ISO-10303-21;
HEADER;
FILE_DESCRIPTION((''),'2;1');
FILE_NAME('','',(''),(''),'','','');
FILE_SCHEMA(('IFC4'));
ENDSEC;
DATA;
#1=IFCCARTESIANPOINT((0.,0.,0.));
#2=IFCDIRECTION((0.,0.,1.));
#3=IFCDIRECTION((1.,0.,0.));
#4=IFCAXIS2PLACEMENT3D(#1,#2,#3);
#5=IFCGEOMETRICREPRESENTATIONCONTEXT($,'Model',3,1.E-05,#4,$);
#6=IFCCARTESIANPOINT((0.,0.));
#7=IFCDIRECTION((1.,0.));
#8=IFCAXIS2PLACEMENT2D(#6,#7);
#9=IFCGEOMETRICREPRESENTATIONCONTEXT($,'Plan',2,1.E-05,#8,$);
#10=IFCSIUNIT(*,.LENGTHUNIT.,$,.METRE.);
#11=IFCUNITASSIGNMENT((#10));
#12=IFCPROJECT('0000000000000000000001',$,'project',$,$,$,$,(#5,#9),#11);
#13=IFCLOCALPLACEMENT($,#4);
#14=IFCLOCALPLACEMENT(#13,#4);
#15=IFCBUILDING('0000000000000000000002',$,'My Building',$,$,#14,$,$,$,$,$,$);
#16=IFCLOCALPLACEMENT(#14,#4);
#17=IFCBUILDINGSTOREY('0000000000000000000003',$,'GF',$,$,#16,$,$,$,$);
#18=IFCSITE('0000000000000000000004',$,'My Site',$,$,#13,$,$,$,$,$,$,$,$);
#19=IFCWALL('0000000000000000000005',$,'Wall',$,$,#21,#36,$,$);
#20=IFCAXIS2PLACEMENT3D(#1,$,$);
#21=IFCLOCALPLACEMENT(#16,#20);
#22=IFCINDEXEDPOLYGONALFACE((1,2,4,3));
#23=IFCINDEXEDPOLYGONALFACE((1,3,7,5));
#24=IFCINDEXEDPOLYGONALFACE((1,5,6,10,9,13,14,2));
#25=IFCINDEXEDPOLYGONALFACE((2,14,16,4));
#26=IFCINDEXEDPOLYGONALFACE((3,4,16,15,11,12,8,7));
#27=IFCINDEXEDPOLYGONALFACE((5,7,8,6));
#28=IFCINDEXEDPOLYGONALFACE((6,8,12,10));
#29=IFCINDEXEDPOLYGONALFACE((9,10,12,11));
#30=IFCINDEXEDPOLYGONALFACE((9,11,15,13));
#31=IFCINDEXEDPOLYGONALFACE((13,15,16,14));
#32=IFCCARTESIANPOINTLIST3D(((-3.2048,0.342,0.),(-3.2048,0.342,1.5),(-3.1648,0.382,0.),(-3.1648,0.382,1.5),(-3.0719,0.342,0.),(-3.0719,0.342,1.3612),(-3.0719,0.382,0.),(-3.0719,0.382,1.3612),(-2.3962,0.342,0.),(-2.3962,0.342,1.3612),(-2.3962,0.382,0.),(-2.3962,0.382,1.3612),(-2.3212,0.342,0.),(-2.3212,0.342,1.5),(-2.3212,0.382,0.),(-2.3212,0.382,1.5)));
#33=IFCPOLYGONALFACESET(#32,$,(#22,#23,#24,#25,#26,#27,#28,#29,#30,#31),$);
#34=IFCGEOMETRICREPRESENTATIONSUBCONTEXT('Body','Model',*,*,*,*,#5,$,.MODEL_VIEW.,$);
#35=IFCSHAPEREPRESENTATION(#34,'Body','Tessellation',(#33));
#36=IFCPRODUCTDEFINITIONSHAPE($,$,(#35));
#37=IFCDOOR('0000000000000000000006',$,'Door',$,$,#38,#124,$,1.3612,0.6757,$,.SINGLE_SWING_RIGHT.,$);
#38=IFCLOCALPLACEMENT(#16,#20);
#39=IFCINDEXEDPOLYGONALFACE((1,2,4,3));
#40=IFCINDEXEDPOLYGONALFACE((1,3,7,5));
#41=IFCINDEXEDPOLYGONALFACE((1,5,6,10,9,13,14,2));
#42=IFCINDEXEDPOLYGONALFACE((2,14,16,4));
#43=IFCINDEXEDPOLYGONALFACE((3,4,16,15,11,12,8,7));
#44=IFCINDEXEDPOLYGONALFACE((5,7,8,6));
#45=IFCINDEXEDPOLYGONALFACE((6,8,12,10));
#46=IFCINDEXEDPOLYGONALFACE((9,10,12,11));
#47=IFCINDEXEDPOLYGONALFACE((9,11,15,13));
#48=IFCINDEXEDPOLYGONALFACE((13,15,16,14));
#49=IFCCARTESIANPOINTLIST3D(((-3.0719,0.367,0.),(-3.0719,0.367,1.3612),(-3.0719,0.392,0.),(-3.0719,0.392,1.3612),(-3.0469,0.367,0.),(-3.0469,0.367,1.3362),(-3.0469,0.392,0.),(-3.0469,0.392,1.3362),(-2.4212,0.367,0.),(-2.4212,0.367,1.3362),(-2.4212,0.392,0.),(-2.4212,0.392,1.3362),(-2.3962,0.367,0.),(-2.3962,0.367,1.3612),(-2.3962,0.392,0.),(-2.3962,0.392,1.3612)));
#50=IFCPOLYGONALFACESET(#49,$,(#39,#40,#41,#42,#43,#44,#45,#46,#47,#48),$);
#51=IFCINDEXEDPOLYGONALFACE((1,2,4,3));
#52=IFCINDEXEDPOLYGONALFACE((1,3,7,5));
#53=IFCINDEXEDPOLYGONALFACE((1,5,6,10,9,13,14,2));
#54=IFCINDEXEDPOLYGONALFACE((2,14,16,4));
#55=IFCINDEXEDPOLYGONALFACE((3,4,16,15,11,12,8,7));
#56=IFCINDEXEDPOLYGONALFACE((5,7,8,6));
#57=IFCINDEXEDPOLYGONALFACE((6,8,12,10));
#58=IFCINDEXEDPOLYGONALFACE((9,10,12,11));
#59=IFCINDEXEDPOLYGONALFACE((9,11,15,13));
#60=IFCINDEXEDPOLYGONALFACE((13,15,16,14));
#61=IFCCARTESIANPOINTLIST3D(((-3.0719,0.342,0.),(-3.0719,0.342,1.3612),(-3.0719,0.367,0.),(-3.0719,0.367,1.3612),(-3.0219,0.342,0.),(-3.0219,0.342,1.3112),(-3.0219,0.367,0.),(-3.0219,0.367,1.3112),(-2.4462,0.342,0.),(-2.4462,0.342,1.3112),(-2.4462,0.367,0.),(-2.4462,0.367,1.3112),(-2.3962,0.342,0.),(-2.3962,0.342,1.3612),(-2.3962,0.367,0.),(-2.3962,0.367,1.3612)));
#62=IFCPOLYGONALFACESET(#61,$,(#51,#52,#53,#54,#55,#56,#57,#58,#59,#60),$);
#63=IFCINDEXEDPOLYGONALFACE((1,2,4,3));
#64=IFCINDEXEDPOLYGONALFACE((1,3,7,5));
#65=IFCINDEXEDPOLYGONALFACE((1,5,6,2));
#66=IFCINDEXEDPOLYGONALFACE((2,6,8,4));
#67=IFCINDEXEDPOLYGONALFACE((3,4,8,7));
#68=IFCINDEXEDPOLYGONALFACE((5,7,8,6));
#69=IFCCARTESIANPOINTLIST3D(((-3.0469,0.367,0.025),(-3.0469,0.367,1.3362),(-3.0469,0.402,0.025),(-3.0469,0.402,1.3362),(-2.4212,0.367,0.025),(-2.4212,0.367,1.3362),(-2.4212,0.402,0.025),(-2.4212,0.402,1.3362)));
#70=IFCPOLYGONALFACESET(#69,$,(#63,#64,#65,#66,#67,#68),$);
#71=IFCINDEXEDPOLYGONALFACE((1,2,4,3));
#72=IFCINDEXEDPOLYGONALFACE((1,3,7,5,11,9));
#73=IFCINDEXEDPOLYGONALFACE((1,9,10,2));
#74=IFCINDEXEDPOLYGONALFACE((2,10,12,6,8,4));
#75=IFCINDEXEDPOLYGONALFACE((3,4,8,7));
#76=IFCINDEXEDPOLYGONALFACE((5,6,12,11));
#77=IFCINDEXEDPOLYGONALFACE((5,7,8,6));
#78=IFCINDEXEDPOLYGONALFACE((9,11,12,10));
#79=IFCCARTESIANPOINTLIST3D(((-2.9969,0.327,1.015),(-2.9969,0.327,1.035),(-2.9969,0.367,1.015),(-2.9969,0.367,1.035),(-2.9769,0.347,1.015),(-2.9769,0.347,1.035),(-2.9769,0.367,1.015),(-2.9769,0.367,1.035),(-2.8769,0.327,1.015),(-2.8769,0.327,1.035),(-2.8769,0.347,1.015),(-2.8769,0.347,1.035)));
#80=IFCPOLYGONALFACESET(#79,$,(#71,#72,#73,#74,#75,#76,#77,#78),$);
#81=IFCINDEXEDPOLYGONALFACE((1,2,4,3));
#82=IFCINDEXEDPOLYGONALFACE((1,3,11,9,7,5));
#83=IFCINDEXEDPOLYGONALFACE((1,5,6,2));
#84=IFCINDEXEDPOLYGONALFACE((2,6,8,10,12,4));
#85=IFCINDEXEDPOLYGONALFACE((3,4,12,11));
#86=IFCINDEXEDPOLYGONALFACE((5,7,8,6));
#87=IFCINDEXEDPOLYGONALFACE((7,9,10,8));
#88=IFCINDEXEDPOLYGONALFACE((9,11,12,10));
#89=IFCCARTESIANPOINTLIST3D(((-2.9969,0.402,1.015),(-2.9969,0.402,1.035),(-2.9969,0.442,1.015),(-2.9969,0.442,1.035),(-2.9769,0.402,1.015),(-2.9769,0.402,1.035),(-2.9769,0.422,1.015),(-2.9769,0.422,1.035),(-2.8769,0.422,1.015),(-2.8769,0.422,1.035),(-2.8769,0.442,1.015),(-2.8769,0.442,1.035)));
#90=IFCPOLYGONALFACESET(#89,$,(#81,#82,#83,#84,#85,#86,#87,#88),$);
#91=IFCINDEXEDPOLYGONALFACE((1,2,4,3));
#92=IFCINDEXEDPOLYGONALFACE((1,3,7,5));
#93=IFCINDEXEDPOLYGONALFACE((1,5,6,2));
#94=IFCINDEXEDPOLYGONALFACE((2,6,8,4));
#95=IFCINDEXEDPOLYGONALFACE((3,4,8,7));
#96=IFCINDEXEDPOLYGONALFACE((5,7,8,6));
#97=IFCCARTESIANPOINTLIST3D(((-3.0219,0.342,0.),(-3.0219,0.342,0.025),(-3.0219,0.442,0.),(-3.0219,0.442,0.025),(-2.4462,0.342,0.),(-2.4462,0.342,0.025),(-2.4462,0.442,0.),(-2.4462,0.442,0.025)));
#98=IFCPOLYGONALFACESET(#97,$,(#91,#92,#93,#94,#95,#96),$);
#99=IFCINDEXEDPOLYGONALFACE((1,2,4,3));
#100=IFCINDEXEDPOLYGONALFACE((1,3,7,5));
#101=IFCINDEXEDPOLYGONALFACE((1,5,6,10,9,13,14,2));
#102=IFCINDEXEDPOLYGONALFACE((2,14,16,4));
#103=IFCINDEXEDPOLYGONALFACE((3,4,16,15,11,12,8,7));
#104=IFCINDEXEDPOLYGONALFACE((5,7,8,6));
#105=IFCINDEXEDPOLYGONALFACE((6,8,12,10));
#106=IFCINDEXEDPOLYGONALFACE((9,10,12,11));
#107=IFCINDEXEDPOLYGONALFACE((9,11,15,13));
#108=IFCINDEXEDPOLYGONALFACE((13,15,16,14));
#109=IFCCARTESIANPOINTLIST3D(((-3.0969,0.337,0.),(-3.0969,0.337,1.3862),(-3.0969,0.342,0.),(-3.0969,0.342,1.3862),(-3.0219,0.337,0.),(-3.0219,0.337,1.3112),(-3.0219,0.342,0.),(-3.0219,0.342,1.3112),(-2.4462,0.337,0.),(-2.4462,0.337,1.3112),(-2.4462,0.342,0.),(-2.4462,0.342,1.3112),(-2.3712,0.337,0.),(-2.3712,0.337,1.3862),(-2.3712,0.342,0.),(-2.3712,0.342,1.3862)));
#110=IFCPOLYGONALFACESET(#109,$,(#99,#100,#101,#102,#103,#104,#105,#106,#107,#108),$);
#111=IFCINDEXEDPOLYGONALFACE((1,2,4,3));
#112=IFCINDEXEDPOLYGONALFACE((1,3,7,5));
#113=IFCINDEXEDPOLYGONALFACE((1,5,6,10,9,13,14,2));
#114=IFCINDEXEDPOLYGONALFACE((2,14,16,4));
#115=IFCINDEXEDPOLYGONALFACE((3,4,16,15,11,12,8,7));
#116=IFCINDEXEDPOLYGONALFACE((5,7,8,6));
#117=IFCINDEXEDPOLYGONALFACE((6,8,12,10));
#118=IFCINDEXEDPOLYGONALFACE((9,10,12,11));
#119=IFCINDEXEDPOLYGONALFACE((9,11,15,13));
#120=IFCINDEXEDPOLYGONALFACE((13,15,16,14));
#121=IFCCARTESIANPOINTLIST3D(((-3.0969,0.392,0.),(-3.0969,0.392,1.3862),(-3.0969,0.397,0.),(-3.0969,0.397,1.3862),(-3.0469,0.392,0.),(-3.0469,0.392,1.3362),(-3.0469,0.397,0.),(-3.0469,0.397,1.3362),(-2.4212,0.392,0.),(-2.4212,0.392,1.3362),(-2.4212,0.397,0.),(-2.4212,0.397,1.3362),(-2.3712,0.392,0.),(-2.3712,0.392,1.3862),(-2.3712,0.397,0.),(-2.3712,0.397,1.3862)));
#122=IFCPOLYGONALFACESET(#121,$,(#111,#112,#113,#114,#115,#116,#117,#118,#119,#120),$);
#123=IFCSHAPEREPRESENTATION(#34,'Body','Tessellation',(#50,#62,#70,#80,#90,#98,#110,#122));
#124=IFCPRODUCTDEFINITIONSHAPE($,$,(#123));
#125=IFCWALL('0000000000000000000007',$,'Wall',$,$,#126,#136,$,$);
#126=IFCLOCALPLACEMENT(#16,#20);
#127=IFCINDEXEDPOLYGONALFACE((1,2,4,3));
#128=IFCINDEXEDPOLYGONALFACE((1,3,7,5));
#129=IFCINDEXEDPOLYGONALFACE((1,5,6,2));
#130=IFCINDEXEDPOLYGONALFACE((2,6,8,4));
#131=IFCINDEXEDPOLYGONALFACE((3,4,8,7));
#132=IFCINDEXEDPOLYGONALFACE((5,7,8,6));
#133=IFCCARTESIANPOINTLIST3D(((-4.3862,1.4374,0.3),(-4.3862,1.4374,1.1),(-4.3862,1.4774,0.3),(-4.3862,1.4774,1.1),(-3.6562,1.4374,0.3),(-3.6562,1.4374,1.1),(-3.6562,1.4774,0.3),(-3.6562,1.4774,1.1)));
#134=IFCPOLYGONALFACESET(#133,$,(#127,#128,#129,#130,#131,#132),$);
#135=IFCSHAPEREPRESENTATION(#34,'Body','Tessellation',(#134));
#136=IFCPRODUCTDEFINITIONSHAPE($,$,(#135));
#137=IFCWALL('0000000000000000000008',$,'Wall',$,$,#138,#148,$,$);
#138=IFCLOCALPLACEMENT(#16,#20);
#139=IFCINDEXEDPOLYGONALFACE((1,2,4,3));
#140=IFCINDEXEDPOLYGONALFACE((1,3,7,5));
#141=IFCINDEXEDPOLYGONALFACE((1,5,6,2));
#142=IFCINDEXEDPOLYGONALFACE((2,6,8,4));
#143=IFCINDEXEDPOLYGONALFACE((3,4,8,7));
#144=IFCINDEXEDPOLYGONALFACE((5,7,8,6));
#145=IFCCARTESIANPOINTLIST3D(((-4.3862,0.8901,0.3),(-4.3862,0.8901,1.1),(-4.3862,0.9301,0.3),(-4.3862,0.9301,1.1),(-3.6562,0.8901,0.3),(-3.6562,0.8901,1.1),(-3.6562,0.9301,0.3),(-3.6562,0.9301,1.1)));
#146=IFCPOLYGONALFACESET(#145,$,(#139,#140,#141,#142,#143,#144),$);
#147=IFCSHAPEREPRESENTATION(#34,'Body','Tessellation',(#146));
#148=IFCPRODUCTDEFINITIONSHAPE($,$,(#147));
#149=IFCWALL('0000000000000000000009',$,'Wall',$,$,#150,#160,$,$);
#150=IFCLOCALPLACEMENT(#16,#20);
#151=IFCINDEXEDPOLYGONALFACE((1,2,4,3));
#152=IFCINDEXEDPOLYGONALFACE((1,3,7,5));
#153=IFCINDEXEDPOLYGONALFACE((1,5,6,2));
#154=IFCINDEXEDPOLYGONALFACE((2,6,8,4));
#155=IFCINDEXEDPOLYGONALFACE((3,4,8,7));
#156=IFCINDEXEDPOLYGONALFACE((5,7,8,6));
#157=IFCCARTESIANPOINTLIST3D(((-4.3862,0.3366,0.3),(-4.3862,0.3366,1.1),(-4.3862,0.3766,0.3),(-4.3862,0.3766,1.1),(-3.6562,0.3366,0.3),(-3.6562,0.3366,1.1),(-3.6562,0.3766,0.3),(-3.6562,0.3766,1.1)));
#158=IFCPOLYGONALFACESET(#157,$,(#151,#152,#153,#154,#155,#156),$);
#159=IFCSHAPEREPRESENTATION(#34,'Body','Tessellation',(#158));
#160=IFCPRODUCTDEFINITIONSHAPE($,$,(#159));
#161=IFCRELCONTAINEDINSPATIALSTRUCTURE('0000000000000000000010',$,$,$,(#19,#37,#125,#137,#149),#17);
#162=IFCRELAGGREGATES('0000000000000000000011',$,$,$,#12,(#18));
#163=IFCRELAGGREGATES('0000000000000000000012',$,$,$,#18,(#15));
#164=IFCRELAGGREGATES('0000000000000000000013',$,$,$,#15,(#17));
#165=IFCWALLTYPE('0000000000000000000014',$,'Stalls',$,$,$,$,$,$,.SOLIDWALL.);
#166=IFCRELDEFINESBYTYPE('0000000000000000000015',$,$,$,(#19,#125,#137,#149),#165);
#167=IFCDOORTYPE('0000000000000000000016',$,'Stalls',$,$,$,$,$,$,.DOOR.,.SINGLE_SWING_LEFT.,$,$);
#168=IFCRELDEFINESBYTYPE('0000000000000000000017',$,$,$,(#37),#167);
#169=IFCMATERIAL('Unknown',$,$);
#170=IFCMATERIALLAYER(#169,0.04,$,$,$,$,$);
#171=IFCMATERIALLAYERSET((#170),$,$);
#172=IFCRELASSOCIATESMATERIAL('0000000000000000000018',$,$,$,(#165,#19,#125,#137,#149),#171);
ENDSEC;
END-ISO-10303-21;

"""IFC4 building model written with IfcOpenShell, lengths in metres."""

from ifc_helpers import new_model, entity, si_unit, frame, origin_with_axes, origin_2d_with_axis, place, context, subcontext, project, spatial, line, indexed_curve, outline, extrude, shape, source, transform, mapped, material, layer, layer_set, layer_usage, type_object, type_shapes, element, fill, save


model = new_model("IFC4")

# Units and contexts
model_context = context("Model", 3, precision=1e-05, world=origin_with_axes())
plan_context = context("Plan", 2, precision=1e-05, world=origin_2d_with_axis())
body_context_1 = subcontext(model_context, "Body", "Model", "MODEL_VIEW")
body_context_2 = subcontext(plan_context, "Body", "Plan", "PLAN_VIEW")
ifc_project = project(units=[si_unit("LENGTHUNIT", "METRE")], contexts=[model_context, plan_context])

# Site, building, storey
site_placement = place(None, origin_with_axes())
site = spatial("IfcSite", under=ifc_project, at=site_placement, Name="My Site")
building_placement = place(site_placement, origin_with_axes())
building = spatial("IfcBuilding", under=site, at=building_placement, Name="My Building")
storey_placement = place(building_placement, origin_with_axes())
storey = spatial("IfcBuildingStorey", under=building, at=storey_placement, Name="GF")

# Shared definitions
ifc_material = material(Name="Unknown")

# Shared definitions
ifc_layer_1 = layer(ifc_material, 0.04)
ifc_layer_set_1 = layer_set([ifc_layer_1])
wall_type_1 = type_object("IfcWallType", Name="Stalls", PredefinedType="SOLIDWALL", material=ifc_layer_set_1)

# Wall, opening, door
ifc_layer_usage_1 = layer_usage(ifc_layer_set_1, "AXIS2", "POSITIVE", 0.0)
wall_1_placement = place(storey_placement, frame((-3.2048, 0.342, 0.0), z_axis=(0.0, 0.0, 1.0), x_axis=(1.0, 0.0, 0.0)))
wall_1 = element("IfcWall", 1, at=wall_1_placement, inside=storey, type_object=wall_type_1, material=ifc_layer_usage_1, Name="Wall", context=body_context_1, shape_type="SweptSolid", body=[
    extrude(outline(indexed_curve([(0.0, 0.0), (0.04, 0.04), (0.8836, 0.04), (0.8836, 0.0)], segments=[line(1, 2, 3, 4, 1)])), origin_with_axes(), (0.0, 0.0, 1.0), 1.5),
])
shared_shape_1 = source(origin_with_axes(), body_context_1, "Body", "SweptSolid", [
    extrude(outline(indexed_curve([(0.0, 0.0), (0.6757, 0.0), (0.6757, 1.3612), (0.0, 1.3612)], segments=[line(1, 2, 3, 4, 1)])), frame((0.0, -0.6, 0.0), z_axis=(0.0, -1.0, 0.0), x_axis=(1.0, 0.0, 0.0)), (0.0, 0.0, -1.0), 1.2),
])
opening_1_placement = place(wall_1_placement, frame((0.133, 0.0, 0.0), z_axis=(0.0, 0.0, 1.0), x_axis=(1.0, 0.0, 0.0)))
opening_1 = element("IfcOpeningElement", 2, at=opening_1_placement, cuts=wall_1, PredefinedType="OPENING", context=body_context_1, shape_type="MappedRepresentation", body=[
    mapped(shared_shape_1, transform((0.0, 0.0, 0.0), x_axis=(1.0, 0.0, 0.0), y_axis=(0.0, 1.0, 0.0), z_axis=(0.0, 0.0, 1.0), scale=1.0)),
])
door_type_1 = type_object("IfcDoorType", Name="Stalls", OperationType="SINGLE_SWING_LEFT", PredefinedType="DOOR")
shared_shape_2 = source(origin_with_axes(), body_context_1, "Body", "SweptSolid", [
    extrude(outline(indexed_curve([(0.0, 0.0), (0.0, 1.3612), (0.6757, 1.3612), (0.6757, 0.0), (0.6507, 0.0), (0.6507, 1.3362), (0.025, 1.3362), (0.025, 0.0)], segments=[line(1, 2, 3, 4, 5, 6, 7, 8, 1)])), frame((0.0, 0.025, 0.0), z_axis=(0.0, -1.0, 0.0), x_axis=(1.0, 0.0, 0.0)), (0.0, 0.0, -1.0), 0.025),
    extrude(outline(indexed_curve([(0.0, 0.0), (0.0, 1.3612), (0.6757, 1.3612), (0.6757, 0.0), (0.6257, 0.0), (0.6257, 1.3112), (0.05, 1.3112), (0.05, 0.0)], segments=[line(1, 2, 3, 4, 5, 6, 7, 8, 1)])), frame((0.0, 0.0, 0.0), z_axis=(0.0, -1.0, 0.0), x_axis=(1.0, 0.0, 0.0)), (0.0, 0.0, -1.0), 0.025),
    extrude(outline(indexed_curve([(0.0, 0.0), (0.6257, 0.0), (0.6257, 0.035), (0.0, 0.035)], segments=[line(1, 2, 3, 4, 1)])), frame((0.025, 0.025, 0.025), z_axis=(0.0, 0.0, 1.0), x_axis=(1.0, 0.0, 0.0)), (0.0, 0.0, 1.0), 1.3112),
    extrude(outline(indexed_curve([(0.0, 0.0), (0.0, -0.04), (0.12, -0.04), (0.12, -0.02), (0.02, -0.02), (0.02, 0.0)], segments=[line(1, 2, 3, 4, 5, 6, 1)])), frame((0.075, 0.025, 1.015), z_axis=(0.0, 0.0, 1.0), x_axis=(1.0, 0.0, 0.0)), (0.0, 0.0, 1.0), 0.02),
    extrude(outline(indexed_curve([(0.0, 0.0), (0.0, 0.04), (0.12, 0.04), (0.12, 0.02), (0.02, 0.02), (0.02, 0.0)], segments=[line(1, 2, 3, 4, 5, 6, 1)])), frame((0.075, 0.06, 1.015), z_axis=(0.0, 0.0, 1.0), x_axis=(1.0, 0.0, 0.0)), (0.0, 0.0, 1.0), 0.02),
    extrude(outline(indexed_curve([(0.0, 0.0), (0.5757, 0.0), (0.5757, 0.1), (0.0, 0.1)], segments=[line(1, 2, 3, 4, 1)])), frame((0.05, 0.0, 0.0), z_axis=(0.0, 0.0, 1.0), x_axis=(1.0, 0.0, 0.0)), (0.0, 0.0, 1.0), 0.025),
    extrude(outline(indexed_curve([(0.0, 0.0), (0.0, 1.3862), (0.7257, 1.3862), (0.7257, 0.0), (0.6507, 0.0), (0.6507, 1.3112), (0.075, 1.3112), (0.075, 0.0)], segments=[line(1, 2, 3, 4, 5, 6, 7, 8, 1)])), frame((-0.025, -0.005, 0.0), z_axis=(0.0, -1.0, 0.0), x_axis=(1.0, 0.0, 0.0)), (0.0, 0.0, -1.0), 0.005),
    extrude(outline(indexed_curve([(0.0, 0.0), (0.0, 1.3862), (0.7257, 1.3862), (0.7257, 0.0), (0.6757, 0.0), (0.6757, 1.3362), (0.05, 1.3362), (0.05, 0.0)], segments=[line(1, 2, 3, 4, 5, 6, 7, 8, 1)])), frame((-0.025, 0.05, 0.0), z_axis=(0.0, -1.0, 0.0), x_axis=(1.0, 0.0, 0.0)), (0.0, 0.0, -1.0), 0.005),
])
shared_shape_3 = source(origin_with_axes(), body_context_2, "Body", "Curve2D", [
    entity("IfcIndexedPolyCurve", entity("IfcCartesianPointList2D", [[0.0, 0.0], [0.0, 0.05], [0.025, 0.05], [0.025, 0.025], [0.05, 0.025], [0.05, 0.0]]), [entity("IfcLineIndex", [1, 2, 3, 4, 5, 6, 1])]),
    entity("IfcIndexedPolyCurve", entity("IfcCartesianPointList2D", [[0.6757, 0.0], [0.6757, 0.05], [0.6507, 0.05], [0.6507, 0.025], [0.6257, 0.025], [0.6257, 0.0]]), [entity("IfcLineIndex", [1, 2, 3, 4, 5, 6, 1])]),
    entity("IfcTrimmedCurve", entity("IfcEllipse", entity("IfcAxis2Placement2D", entity("IfcCartesianPoint", [0.6157, 0.05]), entity("IfcDirection", [1.0, 0.0])), 0.5907, 0.6257), [entity("IfcCartesianPoint", [0.6157, 0.6757])], [entity("IfcCartesianPoint", [0.025, 0.05])], True, "CARTESIAN"),
    entity("IfcIndexedPolyCurve", entity("IfcCartesianPointList2D", [[0.6507, 0.05], [0.6157, 0.05], [0.6157, 0.6757], [0.6507, 0.6757]]), [entity("IfcLineIndex", [1, 2, 3, 4, 1])]),
])
type_shapes(door_type_1, [shared_shape_2, shared_shape_3])
door_1_placement = place(opening_1_placement, frame((0.0, 0.0, 0.0), z_axis=(0.0, 0.0, 1.0), x_axis=(1.0, 0.0, 0.0)))
door_1 = element("IfcDoor", 3, at=door_1_placement, inside=storey, type_object=door_type_1, Name="Door", OperationType="SINGLE_SWING_RIGHT", OverallHeight=1.3612, OverallWidth=0.6757, shapes=[
    shape(body_context_1, "Body", "MappedRepresentation", [mapped(shared_shape_2, transform((0.0, 0.0, 0.0), x_axis=(1.0, 0.0, 0.0), y_axis=(0.0, 1.0, 0.0), z_axis=(0.0, 0.0, 1.0), scale=1.0))]),
    shape(body_context_2, "Body", "MappedRepresentation", [mapped(shared_shape_3, transform((0.0, 0.0, 0.0), x_axis=(1.0, 0.0, 0.0), y_axis=(0.0, 1.0, 0.0), z_axis=(0.0, 0.0, 1.0), scale=1.0))]),
])
fill(opening_1, door_1)

# Walls
ifc_layer_usage_2 = layer_usage(ifc_layer_set_1, "AXIS2", "POSITIVE", 0.0)
wall_2_placement = place(storey_placement, frame((-4.3862, 1.4374, 0.3), z_axis=(0.0, 0.0, 1.0), x_axis=(1.0, 0.0, 0.0)))
element("IfcWall", 4, at=wall_2_placement, inside=storey, type_object=wall_type_1, material=ifc_layer_usage_2, Name="Wall", context=body_context_1, shape_type="SweptSolid", body=[
    extrude(outline(indexed_curve([(0.0, 0.0), (0.0, 0.04), (0.73, 0.04), (0.73, 0.0)], segments=[line(1, 2, 3, 4, 1)])), origin_with_axes(), (0.0, 0.0, 1.0), 0.8),
])
ifc_layer_usage_3 = layer_usage(ifc_layer_set_1, "AXIS2", "POSITIVE", 0.0)
wall_3_placement = place(storey_placement, frame((-4.3862, 0.8901, 0.3), z_axis=(0.0, 0.0, 1.0), x_axis=(1.0, 0.0, 0.0)))
element("IfcWall", 5, at=wall_3_placement, inside=storey, type_object=wall_type_1, material=ifc_layer_usage_3, Name="Wall", context=body_context_1, shape_type="SweptSolid", body=[
    extrude(outline(indexed_curve([(0.0, 0.0), (0.0, 0.04), (0.73, 0.04), (0.73, 0.0)], segments=[line(1, 2, 3, 4, 1)])), origin_with_axes(), (0.0, 0.0, 1.0), 0.8),
])
ifc_layer_usage_4 = layer_usage(ifc_layer_set_1, "AXIS2", "POSITIVE", 0.0)
wall_4_placement = place(storey_placement, frame((-4.3862, 0.3366, 0.3), z_axis=(0.0, 0.0, 1.0), x_axis=(1.0, 0.0, 0.0)))
element("IfcWall", 6, at=wall_4_placement, inside=storey, type_object=wall_type_1, material=ifc_layer_usage_4, Name="Wall", context=body_context_1, shape_type="SweptSolid", body=[
    extrude(outline(indexed_curve([(0.0, 0.0), (0.0, 0.04), (0.73, 0.04), (0.73, 0.0)], segments=[line(1, 2, 3, 4, 1)])), origin_with_axes(), (0.0, 0.0, 1.0), 0.8),
])

save(model, "model.ifc")
